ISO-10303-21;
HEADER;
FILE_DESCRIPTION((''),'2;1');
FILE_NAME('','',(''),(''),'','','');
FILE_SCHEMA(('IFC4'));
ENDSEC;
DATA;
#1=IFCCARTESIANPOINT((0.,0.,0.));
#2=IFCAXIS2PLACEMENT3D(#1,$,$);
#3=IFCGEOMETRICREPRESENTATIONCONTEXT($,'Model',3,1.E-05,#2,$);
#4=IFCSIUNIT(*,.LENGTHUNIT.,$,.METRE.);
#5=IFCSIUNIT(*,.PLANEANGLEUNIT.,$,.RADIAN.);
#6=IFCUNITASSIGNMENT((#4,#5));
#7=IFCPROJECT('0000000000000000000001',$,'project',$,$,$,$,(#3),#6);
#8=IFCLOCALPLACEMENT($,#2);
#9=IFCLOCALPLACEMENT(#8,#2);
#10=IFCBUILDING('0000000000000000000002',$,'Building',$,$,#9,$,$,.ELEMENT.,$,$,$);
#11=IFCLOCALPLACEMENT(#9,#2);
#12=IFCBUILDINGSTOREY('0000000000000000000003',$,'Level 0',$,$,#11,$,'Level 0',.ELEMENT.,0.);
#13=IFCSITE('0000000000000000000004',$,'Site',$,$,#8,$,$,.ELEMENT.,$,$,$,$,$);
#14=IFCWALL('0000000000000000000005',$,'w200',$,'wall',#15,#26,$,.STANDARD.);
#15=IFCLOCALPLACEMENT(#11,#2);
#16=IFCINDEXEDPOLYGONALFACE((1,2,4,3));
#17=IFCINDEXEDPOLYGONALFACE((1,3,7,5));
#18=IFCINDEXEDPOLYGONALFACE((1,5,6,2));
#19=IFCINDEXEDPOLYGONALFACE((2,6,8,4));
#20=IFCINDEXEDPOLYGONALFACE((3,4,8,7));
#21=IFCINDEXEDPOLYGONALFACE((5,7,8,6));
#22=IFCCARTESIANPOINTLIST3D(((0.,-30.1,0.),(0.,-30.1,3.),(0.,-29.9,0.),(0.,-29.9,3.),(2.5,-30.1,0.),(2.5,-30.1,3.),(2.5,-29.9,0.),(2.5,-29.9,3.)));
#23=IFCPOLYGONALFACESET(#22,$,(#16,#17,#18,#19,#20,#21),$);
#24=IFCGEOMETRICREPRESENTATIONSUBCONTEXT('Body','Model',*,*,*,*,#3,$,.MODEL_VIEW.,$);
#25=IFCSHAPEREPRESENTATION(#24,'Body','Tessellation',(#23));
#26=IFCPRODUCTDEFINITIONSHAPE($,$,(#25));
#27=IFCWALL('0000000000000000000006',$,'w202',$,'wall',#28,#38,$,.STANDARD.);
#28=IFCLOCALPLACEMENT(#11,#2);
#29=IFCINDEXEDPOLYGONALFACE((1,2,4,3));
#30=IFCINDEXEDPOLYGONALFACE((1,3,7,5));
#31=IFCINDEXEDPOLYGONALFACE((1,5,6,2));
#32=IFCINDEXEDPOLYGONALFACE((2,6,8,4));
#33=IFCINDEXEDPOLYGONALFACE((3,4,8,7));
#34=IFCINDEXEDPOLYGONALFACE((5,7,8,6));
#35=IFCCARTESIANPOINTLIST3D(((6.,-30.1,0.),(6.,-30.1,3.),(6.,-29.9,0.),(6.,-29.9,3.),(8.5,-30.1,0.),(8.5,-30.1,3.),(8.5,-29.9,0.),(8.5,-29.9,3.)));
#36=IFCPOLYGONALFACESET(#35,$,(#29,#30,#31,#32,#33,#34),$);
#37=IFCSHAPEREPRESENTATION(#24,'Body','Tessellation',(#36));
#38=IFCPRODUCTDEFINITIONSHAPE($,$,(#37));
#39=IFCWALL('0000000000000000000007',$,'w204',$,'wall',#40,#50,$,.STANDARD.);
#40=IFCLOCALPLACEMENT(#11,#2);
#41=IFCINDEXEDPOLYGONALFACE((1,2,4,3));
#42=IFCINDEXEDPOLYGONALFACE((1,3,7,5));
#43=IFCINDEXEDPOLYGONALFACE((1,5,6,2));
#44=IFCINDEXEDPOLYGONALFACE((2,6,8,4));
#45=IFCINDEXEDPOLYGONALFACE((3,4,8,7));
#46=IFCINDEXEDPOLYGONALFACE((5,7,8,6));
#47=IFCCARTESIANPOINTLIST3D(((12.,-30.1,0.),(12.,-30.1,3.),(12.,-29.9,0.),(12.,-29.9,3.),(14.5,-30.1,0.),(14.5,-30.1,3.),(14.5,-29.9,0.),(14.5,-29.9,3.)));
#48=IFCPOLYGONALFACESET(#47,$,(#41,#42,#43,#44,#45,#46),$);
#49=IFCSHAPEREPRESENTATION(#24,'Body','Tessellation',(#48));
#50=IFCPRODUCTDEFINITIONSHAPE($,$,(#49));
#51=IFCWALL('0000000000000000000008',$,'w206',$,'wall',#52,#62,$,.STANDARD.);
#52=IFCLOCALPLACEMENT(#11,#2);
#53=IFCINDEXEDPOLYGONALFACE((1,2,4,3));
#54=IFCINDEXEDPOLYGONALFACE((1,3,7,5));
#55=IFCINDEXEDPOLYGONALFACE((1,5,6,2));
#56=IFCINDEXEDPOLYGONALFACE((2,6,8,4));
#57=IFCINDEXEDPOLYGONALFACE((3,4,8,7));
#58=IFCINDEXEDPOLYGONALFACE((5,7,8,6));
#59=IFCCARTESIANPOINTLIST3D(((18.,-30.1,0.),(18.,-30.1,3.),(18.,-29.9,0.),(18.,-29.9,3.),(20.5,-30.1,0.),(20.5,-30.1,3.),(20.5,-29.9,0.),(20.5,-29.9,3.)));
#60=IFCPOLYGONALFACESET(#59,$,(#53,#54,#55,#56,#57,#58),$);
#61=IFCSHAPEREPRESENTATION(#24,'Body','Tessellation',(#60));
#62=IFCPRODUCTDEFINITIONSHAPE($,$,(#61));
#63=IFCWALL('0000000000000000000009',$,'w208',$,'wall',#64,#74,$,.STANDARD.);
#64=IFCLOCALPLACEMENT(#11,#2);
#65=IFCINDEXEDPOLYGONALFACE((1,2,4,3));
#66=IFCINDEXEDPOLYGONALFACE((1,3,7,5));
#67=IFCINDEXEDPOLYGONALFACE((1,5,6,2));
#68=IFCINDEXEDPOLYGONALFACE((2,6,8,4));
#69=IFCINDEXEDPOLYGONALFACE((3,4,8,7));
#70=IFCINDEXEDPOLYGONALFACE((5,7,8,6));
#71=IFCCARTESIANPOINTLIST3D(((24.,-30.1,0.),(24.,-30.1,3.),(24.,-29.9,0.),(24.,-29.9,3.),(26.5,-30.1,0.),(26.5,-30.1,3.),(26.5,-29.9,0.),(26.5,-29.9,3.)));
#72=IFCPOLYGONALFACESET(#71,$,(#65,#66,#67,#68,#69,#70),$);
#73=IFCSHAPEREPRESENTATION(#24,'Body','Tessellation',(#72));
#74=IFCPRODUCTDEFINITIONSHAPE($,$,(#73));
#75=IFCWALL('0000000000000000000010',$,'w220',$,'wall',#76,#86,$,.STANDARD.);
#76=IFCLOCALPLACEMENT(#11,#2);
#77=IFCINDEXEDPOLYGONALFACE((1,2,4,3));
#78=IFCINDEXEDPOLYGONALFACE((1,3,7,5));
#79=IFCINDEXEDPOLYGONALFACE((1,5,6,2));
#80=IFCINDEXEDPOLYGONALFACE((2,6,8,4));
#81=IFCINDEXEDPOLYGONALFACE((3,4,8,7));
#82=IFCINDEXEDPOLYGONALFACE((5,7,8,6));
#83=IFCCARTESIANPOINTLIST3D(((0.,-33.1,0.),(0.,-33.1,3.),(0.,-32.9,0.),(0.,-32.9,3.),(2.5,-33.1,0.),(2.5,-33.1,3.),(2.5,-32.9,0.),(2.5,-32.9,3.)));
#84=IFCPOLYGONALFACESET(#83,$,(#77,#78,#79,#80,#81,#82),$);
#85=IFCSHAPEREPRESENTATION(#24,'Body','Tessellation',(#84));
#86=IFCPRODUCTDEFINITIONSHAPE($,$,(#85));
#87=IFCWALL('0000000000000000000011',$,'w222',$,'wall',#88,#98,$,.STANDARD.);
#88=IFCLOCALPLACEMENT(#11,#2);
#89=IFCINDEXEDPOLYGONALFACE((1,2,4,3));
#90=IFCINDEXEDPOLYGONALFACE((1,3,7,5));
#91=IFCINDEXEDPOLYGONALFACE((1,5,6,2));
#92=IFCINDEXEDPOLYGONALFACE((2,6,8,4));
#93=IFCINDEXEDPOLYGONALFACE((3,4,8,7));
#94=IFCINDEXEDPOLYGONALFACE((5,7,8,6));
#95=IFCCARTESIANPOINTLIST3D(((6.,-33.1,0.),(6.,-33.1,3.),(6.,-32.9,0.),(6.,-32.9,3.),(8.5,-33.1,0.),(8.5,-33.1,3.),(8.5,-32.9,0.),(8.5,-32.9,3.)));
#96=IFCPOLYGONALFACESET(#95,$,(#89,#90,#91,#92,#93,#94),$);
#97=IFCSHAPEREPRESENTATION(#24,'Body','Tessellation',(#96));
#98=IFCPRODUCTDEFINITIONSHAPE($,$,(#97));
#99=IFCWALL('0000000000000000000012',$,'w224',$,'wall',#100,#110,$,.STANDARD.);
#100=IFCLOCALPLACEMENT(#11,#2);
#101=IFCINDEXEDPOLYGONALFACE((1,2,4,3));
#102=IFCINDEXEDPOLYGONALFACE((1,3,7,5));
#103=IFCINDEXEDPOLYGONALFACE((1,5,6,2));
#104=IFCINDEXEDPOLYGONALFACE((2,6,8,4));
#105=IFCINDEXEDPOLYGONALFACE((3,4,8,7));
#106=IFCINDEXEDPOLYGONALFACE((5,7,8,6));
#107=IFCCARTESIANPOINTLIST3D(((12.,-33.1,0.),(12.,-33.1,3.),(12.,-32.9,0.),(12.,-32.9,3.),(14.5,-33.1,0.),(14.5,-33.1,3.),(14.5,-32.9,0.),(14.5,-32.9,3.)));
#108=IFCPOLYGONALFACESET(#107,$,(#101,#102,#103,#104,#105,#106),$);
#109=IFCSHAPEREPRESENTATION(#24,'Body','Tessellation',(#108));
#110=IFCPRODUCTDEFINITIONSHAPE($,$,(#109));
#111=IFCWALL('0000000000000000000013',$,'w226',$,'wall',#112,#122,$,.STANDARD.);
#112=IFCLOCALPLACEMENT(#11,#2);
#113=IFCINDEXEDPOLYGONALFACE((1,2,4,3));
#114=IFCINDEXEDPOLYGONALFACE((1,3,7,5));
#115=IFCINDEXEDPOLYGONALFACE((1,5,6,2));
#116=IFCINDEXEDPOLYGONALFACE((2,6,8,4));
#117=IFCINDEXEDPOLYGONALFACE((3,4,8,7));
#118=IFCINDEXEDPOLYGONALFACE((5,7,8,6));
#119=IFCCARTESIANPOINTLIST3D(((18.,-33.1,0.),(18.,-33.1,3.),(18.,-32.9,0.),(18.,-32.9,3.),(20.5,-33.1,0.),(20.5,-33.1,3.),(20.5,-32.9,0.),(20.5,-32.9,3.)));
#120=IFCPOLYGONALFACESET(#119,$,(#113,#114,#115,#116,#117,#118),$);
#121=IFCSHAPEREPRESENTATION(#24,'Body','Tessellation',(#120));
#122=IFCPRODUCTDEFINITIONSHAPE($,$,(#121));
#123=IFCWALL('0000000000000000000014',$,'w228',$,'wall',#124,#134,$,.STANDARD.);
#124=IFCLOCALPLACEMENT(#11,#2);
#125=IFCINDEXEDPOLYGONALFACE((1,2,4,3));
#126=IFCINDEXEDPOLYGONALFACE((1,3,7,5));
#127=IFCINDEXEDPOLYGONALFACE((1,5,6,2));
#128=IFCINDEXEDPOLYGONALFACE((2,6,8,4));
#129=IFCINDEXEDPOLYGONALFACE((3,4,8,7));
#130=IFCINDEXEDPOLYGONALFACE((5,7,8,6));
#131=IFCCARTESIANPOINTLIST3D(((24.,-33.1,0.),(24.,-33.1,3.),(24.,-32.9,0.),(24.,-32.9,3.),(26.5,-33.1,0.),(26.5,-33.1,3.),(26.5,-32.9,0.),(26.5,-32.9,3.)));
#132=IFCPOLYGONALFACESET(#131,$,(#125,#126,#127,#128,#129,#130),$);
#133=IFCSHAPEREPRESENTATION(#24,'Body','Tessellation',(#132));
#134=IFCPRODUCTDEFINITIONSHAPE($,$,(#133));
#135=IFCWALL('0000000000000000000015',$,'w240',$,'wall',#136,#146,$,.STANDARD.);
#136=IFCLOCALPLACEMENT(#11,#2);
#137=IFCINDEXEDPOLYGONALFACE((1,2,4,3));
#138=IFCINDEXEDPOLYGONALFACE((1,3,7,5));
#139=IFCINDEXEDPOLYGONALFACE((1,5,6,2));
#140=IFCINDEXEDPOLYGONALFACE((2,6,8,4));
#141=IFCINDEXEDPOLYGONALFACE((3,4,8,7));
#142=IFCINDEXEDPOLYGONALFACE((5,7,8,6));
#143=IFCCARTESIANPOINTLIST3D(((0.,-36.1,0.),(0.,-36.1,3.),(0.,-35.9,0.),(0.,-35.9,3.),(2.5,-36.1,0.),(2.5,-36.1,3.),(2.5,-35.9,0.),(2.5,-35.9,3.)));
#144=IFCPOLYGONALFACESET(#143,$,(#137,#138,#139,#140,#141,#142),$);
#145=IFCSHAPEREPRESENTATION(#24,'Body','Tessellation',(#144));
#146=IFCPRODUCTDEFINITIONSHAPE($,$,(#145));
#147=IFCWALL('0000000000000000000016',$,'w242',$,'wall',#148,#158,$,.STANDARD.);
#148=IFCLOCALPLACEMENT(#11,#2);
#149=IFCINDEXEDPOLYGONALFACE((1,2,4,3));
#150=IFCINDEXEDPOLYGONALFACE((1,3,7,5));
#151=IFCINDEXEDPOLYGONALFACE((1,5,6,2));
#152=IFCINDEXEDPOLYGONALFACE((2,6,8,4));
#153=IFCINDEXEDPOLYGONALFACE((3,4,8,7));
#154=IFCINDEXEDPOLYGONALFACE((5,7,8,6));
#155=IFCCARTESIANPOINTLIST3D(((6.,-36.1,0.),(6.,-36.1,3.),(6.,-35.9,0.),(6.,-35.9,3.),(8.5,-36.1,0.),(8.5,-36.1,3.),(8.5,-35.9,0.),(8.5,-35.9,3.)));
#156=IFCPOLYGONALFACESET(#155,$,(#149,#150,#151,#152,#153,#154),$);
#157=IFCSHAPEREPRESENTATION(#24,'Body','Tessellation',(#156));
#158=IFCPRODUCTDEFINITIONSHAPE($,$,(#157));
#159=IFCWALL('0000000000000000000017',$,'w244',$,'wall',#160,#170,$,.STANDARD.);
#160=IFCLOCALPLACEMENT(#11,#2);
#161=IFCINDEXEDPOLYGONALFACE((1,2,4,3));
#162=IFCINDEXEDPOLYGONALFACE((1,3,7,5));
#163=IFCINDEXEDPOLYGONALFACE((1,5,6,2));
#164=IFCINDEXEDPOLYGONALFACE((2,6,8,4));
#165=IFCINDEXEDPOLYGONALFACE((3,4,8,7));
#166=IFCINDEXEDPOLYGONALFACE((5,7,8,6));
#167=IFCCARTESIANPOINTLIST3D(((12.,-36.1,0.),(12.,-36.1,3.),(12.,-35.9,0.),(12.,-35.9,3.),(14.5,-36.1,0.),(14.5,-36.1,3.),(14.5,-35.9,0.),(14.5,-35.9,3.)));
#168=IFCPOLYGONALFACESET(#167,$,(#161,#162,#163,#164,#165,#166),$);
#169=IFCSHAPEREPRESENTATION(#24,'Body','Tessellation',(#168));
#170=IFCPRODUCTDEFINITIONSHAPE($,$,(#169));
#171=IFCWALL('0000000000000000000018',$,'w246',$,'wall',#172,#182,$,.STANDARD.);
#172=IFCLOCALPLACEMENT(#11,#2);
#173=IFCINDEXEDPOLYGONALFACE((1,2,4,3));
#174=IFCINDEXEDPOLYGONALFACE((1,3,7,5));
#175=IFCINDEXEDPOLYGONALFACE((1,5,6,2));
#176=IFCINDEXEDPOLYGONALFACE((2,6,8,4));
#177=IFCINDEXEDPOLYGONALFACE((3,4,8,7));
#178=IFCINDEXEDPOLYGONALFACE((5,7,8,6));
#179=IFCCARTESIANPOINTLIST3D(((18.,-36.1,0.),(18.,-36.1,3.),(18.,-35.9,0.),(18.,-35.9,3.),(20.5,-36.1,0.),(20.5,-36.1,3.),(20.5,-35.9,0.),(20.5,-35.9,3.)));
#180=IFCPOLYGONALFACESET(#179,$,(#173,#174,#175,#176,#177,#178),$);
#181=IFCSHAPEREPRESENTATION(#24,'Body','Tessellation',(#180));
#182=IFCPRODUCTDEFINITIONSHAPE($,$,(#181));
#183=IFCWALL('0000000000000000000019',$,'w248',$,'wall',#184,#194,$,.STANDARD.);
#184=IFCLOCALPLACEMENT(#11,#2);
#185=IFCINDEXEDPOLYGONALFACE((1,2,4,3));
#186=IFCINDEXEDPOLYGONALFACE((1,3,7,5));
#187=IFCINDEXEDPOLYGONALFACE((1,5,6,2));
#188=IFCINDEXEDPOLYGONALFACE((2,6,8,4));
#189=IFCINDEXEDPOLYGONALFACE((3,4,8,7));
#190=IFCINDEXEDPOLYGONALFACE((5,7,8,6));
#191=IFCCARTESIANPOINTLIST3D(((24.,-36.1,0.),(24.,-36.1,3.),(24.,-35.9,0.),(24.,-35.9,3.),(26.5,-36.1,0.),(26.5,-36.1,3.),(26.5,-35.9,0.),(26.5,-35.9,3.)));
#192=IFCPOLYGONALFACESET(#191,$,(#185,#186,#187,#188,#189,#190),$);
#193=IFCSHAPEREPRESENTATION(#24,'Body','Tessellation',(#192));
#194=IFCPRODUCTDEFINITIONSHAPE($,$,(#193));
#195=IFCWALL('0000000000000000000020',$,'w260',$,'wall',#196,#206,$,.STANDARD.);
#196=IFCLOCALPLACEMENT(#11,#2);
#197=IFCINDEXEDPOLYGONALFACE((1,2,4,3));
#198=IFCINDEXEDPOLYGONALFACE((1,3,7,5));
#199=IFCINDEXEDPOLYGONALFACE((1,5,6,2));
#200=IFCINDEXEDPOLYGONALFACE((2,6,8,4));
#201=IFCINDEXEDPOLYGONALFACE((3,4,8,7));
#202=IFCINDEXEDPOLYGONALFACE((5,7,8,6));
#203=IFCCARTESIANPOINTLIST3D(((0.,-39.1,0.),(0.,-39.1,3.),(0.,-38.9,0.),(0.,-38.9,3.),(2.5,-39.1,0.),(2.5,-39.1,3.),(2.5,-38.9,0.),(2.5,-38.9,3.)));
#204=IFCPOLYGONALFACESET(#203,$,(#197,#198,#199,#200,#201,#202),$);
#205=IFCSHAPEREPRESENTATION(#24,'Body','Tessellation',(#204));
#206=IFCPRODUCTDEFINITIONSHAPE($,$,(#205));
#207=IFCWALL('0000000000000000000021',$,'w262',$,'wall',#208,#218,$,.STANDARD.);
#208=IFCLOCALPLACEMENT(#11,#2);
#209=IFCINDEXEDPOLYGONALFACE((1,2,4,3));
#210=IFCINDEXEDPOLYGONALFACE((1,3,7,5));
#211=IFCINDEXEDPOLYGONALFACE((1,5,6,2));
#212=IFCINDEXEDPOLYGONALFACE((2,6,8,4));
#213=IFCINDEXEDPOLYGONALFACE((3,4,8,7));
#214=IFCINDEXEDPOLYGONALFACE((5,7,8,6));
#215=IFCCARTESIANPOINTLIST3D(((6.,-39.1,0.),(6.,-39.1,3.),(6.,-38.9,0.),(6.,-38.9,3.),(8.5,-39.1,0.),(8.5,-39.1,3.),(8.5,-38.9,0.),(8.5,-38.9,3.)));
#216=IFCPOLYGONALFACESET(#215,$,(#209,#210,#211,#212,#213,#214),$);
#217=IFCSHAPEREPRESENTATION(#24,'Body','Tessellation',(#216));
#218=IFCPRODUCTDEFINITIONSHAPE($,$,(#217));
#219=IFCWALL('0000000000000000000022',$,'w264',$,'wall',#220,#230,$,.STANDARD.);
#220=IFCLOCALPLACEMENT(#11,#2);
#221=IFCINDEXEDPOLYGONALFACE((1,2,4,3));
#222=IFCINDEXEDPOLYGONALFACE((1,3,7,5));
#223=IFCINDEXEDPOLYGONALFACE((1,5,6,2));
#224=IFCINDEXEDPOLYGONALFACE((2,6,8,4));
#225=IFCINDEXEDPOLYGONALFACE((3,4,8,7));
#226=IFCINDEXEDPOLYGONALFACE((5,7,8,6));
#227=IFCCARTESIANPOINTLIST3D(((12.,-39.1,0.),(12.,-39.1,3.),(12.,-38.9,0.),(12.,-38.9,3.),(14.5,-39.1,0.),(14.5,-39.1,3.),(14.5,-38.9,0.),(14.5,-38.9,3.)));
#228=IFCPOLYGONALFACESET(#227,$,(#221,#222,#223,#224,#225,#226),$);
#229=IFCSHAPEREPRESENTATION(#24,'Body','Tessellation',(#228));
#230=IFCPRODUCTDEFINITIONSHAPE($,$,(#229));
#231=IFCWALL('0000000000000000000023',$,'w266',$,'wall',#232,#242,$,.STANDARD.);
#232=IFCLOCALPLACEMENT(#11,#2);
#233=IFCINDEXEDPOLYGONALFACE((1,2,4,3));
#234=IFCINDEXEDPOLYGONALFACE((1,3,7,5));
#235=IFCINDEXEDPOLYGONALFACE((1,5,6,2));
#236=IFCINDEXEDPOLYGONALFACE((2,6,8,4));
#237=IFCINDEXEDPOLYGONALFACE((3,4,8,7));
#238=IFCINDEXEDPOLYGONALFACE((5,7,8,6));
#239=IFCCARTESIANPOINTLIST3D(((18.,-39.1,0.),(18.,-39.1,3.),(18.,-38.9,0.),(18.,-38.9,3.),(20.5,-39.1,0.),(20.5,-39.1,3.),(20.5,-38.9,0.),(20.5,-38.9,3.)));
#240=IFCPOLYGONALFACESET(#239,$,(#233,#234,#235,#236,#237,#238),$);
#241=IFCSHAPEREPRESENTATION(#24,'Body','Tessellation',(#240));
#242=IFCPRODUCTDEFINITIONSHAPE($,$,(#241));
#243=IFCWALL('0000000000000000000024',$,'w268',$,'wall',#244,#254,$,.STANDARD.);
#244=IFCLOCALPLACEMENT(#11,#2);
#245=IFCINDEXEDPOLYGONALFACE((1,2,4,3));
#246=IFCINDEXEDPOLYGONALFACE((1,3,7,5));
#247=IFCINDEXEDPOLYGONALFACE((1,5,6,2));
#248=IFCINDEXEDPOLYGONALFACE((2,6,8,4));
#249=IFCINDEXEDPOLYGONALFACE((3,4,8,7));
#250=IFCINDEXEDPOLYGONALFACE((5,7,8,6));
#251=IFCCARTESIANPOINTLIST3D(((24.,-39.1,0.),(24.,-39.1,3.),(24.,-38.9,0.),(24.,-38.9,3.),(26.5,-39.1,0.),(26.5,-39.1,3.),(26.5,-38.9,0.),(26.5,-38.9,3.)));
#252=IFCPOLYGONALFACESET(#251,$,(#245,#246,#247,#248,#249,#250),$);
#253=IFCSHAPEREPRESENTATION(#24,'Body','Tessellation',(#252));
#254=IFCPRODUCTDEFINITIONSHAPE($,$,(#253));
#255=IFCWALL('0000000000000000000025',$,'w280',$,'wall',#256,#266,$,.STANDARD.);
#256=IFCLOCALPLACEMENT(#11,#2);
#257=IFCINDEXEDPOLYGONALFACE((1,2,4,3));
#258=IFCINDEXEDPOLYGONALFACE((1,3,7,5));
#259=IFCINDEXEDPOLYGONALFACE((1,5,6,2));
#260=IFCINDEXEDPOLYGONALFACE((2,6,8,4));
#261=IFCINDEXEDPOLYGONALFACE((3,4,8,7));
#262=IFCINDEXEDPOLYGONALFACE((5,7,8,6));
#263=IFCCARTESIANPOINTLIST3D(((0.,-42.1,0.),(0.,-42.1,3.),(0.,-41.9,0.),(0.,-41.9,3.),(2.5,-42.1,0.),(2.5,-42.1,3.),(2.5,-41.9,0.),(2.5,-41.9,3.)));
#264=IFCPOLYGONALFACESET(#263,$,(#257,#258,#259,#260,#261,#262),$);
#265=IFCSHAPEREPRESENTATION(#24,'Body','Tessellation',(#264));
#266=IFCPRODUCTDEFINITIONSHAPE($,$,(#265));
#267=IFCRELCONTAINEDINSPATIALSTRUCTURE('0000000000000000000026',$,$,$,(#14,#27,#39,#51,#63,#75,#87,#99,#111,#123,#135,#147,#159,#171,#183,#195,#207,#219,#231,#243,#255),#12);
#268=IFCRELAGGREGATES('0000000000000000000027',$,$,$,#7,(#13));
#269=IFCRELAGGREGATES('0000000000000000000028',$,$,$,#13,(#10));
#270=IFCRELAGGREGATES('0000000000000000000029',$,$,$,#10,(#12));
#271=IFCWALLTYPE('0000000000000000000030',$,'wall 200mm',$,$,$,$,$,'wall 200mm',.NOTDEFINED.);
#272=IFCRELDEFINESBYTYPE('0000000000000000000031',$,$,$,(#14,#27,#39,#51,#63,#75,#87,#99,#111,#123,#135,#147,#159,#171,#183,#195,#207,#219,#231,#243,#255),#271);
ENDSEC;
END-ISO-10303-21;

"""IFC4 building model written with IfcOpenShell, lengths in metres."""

from ifc_helpers import new_model, si_unit, frame, frame_2d, origin, place, context, subcontext, project, spatial, rectangle, extrude, type_object, element, save


model = new_model("IFC4")

# Units and contexts
model_context = context("Model", 3, precision=1e-05, world=origin())
body_context = subcontext(model_context, "Body", "Model", "MODEL_VIEW")
ifc_project = project(units=[si_unit("LENGTHUNIT", "METRE"), si_unit("PLANEANGLEUNIT", "RADIAN")], contexts=[model_context])

# Site, building, storey
site_placement = place(None, origin())
site = spatial("IfcSite", under=ifc_project, at=site_placement, Name="Site", CompositionType="ELEMENT")
building_placement = place(site_placement, origin())
building = spatial("IfcBuilding", under=site, at=building_placement, Name="Building", CompositionType="ELEMENT")
storey_placement = place(building_placement, origin())
storey = spatial("IfcBuildingStorey", under=building, at=storey_placement, Name="Level 0", LongName="Level 0", CompositionType="ELEMENT", Elevation=0.0)

# Walls
wall_type = type_object("IfcWallType", Name="wall 200mm", ElementType="wall 200mm", PredefinedType="NOTDEFINED")
for number, where, z_axis, x_axis, name in (
    (1, (0.0, -30.0, 0.0), (0.0, 0.0, 1.0), (1.0, 0.0, 0.0), "w200"),
    (2, (6.0, -30.0, 0.0), (0.0, 0.0, 1.0), (1.0, 0.0, 0.0), "w202"),
    (3, (12.0, -30.0, 0.0), (0.0, 0.0, 1.0), (1.0, 0.0, 0.0), "w204"),
    (4, (18.0, -30.0, 0.0), (0.0, 0.0, 1.0), (1.0, 0.0, 0.0), "w206"),
    (5, (24.0, -30.0, 0.0), (0.0, 0.0, 1.0), (1.0, 0.0, 0.0), "w208"),
    (6, (0.0, -33.0, 0.0), (0.0, 0.0, 1.0), (1.0, 0.0, 0.0), "w220"),
    (7, (6.0, -33.0, 0.0), (0.0, 0.0, 1.0), (1.0, 0.0, 0.0), "w222"),
    (8, (12.0, -33.0, 0.0), (0.0, 0.0, 1.0), (1.0, 0.0, 0.0), "w224"),
    (9, (18.0, -33.0, 0.0), (0.0, 0.0, 1.0), (1.0, 0.0, 0.0), "w226"),
    (10, (24.0, -33.0, 0.0), (0.0, 0.0, 1.0), (1.0, 0.0, 0.0), "w228"),
    (11, (0.0, -36.0, 0.0), (0.0, 0.0, 1.0), (1.0, 0.0, 0.0), "w240"),
    (12, (6.0, -36.0, 0.0), (0.0, 0.0, 1.0), (1.0, 0.0, 0.0), "w242"),
    (13, (12.0, -36.0, 0.0), (0.0, 0.0, 1.0), (1.0, 0.0, 0.0), "w244"),
    (14, (18.0, -36.0, 0.0), (0.0, 0.0, 1.0), (1.0, 0.0, 0.0), "w246"),
    (15, (24.0, -36.0, 0.0), (0.0, 0.0, 1.0), (1.0, 0.0, 0.0), "w248"),
    (16, (0.0, -39.0, 0.0), (0.0, 0.0, 1.0), (1.0, 0.0, 0.0), "w260"),
    (17, (6.0, -39.0, 0.0), (0.0, 0.0, 1.0), (1.0, 0.0, 0.0), "w262"),
    (18, (12.0, -39.0, 0.0), (0.0, 0.0, 1.0), (1.0, 0.0, 0.0), "w264"),
    (19, (18.0, -39.0, 0.0), (0.0, 0.0, 1.0), (1.0, 0.0, 0.0), "w266"),
    (20, (24.0, -39.0, 0.0), (0.0, 0.0, 1.0), (1.0, 0.0, 0.0), "w268"),
    (21, (0.0, -42.0, 0.0), (0.0, 0.0, 1.0), (1.0, 0.0, 0.0), "w280"),
):
    element("IfcWall", number, at=place(storey_placement, frame(where, z_axis=z_axis, x_axis=x_axis)), inside=storey, type_object=wall_type, Name=name, ObjectType="wall", PredefinedType="STANDARD", context=body_context, shape_type="SweptSolid", body=[
        extrude(rectangle(XDim=2.5, YDim=0.2, at=frame_2d((1.25, 0.0))), origin(), (0.0, 0.0, 1.0), 3.0),
    ])

save(model, "model.ifc")
